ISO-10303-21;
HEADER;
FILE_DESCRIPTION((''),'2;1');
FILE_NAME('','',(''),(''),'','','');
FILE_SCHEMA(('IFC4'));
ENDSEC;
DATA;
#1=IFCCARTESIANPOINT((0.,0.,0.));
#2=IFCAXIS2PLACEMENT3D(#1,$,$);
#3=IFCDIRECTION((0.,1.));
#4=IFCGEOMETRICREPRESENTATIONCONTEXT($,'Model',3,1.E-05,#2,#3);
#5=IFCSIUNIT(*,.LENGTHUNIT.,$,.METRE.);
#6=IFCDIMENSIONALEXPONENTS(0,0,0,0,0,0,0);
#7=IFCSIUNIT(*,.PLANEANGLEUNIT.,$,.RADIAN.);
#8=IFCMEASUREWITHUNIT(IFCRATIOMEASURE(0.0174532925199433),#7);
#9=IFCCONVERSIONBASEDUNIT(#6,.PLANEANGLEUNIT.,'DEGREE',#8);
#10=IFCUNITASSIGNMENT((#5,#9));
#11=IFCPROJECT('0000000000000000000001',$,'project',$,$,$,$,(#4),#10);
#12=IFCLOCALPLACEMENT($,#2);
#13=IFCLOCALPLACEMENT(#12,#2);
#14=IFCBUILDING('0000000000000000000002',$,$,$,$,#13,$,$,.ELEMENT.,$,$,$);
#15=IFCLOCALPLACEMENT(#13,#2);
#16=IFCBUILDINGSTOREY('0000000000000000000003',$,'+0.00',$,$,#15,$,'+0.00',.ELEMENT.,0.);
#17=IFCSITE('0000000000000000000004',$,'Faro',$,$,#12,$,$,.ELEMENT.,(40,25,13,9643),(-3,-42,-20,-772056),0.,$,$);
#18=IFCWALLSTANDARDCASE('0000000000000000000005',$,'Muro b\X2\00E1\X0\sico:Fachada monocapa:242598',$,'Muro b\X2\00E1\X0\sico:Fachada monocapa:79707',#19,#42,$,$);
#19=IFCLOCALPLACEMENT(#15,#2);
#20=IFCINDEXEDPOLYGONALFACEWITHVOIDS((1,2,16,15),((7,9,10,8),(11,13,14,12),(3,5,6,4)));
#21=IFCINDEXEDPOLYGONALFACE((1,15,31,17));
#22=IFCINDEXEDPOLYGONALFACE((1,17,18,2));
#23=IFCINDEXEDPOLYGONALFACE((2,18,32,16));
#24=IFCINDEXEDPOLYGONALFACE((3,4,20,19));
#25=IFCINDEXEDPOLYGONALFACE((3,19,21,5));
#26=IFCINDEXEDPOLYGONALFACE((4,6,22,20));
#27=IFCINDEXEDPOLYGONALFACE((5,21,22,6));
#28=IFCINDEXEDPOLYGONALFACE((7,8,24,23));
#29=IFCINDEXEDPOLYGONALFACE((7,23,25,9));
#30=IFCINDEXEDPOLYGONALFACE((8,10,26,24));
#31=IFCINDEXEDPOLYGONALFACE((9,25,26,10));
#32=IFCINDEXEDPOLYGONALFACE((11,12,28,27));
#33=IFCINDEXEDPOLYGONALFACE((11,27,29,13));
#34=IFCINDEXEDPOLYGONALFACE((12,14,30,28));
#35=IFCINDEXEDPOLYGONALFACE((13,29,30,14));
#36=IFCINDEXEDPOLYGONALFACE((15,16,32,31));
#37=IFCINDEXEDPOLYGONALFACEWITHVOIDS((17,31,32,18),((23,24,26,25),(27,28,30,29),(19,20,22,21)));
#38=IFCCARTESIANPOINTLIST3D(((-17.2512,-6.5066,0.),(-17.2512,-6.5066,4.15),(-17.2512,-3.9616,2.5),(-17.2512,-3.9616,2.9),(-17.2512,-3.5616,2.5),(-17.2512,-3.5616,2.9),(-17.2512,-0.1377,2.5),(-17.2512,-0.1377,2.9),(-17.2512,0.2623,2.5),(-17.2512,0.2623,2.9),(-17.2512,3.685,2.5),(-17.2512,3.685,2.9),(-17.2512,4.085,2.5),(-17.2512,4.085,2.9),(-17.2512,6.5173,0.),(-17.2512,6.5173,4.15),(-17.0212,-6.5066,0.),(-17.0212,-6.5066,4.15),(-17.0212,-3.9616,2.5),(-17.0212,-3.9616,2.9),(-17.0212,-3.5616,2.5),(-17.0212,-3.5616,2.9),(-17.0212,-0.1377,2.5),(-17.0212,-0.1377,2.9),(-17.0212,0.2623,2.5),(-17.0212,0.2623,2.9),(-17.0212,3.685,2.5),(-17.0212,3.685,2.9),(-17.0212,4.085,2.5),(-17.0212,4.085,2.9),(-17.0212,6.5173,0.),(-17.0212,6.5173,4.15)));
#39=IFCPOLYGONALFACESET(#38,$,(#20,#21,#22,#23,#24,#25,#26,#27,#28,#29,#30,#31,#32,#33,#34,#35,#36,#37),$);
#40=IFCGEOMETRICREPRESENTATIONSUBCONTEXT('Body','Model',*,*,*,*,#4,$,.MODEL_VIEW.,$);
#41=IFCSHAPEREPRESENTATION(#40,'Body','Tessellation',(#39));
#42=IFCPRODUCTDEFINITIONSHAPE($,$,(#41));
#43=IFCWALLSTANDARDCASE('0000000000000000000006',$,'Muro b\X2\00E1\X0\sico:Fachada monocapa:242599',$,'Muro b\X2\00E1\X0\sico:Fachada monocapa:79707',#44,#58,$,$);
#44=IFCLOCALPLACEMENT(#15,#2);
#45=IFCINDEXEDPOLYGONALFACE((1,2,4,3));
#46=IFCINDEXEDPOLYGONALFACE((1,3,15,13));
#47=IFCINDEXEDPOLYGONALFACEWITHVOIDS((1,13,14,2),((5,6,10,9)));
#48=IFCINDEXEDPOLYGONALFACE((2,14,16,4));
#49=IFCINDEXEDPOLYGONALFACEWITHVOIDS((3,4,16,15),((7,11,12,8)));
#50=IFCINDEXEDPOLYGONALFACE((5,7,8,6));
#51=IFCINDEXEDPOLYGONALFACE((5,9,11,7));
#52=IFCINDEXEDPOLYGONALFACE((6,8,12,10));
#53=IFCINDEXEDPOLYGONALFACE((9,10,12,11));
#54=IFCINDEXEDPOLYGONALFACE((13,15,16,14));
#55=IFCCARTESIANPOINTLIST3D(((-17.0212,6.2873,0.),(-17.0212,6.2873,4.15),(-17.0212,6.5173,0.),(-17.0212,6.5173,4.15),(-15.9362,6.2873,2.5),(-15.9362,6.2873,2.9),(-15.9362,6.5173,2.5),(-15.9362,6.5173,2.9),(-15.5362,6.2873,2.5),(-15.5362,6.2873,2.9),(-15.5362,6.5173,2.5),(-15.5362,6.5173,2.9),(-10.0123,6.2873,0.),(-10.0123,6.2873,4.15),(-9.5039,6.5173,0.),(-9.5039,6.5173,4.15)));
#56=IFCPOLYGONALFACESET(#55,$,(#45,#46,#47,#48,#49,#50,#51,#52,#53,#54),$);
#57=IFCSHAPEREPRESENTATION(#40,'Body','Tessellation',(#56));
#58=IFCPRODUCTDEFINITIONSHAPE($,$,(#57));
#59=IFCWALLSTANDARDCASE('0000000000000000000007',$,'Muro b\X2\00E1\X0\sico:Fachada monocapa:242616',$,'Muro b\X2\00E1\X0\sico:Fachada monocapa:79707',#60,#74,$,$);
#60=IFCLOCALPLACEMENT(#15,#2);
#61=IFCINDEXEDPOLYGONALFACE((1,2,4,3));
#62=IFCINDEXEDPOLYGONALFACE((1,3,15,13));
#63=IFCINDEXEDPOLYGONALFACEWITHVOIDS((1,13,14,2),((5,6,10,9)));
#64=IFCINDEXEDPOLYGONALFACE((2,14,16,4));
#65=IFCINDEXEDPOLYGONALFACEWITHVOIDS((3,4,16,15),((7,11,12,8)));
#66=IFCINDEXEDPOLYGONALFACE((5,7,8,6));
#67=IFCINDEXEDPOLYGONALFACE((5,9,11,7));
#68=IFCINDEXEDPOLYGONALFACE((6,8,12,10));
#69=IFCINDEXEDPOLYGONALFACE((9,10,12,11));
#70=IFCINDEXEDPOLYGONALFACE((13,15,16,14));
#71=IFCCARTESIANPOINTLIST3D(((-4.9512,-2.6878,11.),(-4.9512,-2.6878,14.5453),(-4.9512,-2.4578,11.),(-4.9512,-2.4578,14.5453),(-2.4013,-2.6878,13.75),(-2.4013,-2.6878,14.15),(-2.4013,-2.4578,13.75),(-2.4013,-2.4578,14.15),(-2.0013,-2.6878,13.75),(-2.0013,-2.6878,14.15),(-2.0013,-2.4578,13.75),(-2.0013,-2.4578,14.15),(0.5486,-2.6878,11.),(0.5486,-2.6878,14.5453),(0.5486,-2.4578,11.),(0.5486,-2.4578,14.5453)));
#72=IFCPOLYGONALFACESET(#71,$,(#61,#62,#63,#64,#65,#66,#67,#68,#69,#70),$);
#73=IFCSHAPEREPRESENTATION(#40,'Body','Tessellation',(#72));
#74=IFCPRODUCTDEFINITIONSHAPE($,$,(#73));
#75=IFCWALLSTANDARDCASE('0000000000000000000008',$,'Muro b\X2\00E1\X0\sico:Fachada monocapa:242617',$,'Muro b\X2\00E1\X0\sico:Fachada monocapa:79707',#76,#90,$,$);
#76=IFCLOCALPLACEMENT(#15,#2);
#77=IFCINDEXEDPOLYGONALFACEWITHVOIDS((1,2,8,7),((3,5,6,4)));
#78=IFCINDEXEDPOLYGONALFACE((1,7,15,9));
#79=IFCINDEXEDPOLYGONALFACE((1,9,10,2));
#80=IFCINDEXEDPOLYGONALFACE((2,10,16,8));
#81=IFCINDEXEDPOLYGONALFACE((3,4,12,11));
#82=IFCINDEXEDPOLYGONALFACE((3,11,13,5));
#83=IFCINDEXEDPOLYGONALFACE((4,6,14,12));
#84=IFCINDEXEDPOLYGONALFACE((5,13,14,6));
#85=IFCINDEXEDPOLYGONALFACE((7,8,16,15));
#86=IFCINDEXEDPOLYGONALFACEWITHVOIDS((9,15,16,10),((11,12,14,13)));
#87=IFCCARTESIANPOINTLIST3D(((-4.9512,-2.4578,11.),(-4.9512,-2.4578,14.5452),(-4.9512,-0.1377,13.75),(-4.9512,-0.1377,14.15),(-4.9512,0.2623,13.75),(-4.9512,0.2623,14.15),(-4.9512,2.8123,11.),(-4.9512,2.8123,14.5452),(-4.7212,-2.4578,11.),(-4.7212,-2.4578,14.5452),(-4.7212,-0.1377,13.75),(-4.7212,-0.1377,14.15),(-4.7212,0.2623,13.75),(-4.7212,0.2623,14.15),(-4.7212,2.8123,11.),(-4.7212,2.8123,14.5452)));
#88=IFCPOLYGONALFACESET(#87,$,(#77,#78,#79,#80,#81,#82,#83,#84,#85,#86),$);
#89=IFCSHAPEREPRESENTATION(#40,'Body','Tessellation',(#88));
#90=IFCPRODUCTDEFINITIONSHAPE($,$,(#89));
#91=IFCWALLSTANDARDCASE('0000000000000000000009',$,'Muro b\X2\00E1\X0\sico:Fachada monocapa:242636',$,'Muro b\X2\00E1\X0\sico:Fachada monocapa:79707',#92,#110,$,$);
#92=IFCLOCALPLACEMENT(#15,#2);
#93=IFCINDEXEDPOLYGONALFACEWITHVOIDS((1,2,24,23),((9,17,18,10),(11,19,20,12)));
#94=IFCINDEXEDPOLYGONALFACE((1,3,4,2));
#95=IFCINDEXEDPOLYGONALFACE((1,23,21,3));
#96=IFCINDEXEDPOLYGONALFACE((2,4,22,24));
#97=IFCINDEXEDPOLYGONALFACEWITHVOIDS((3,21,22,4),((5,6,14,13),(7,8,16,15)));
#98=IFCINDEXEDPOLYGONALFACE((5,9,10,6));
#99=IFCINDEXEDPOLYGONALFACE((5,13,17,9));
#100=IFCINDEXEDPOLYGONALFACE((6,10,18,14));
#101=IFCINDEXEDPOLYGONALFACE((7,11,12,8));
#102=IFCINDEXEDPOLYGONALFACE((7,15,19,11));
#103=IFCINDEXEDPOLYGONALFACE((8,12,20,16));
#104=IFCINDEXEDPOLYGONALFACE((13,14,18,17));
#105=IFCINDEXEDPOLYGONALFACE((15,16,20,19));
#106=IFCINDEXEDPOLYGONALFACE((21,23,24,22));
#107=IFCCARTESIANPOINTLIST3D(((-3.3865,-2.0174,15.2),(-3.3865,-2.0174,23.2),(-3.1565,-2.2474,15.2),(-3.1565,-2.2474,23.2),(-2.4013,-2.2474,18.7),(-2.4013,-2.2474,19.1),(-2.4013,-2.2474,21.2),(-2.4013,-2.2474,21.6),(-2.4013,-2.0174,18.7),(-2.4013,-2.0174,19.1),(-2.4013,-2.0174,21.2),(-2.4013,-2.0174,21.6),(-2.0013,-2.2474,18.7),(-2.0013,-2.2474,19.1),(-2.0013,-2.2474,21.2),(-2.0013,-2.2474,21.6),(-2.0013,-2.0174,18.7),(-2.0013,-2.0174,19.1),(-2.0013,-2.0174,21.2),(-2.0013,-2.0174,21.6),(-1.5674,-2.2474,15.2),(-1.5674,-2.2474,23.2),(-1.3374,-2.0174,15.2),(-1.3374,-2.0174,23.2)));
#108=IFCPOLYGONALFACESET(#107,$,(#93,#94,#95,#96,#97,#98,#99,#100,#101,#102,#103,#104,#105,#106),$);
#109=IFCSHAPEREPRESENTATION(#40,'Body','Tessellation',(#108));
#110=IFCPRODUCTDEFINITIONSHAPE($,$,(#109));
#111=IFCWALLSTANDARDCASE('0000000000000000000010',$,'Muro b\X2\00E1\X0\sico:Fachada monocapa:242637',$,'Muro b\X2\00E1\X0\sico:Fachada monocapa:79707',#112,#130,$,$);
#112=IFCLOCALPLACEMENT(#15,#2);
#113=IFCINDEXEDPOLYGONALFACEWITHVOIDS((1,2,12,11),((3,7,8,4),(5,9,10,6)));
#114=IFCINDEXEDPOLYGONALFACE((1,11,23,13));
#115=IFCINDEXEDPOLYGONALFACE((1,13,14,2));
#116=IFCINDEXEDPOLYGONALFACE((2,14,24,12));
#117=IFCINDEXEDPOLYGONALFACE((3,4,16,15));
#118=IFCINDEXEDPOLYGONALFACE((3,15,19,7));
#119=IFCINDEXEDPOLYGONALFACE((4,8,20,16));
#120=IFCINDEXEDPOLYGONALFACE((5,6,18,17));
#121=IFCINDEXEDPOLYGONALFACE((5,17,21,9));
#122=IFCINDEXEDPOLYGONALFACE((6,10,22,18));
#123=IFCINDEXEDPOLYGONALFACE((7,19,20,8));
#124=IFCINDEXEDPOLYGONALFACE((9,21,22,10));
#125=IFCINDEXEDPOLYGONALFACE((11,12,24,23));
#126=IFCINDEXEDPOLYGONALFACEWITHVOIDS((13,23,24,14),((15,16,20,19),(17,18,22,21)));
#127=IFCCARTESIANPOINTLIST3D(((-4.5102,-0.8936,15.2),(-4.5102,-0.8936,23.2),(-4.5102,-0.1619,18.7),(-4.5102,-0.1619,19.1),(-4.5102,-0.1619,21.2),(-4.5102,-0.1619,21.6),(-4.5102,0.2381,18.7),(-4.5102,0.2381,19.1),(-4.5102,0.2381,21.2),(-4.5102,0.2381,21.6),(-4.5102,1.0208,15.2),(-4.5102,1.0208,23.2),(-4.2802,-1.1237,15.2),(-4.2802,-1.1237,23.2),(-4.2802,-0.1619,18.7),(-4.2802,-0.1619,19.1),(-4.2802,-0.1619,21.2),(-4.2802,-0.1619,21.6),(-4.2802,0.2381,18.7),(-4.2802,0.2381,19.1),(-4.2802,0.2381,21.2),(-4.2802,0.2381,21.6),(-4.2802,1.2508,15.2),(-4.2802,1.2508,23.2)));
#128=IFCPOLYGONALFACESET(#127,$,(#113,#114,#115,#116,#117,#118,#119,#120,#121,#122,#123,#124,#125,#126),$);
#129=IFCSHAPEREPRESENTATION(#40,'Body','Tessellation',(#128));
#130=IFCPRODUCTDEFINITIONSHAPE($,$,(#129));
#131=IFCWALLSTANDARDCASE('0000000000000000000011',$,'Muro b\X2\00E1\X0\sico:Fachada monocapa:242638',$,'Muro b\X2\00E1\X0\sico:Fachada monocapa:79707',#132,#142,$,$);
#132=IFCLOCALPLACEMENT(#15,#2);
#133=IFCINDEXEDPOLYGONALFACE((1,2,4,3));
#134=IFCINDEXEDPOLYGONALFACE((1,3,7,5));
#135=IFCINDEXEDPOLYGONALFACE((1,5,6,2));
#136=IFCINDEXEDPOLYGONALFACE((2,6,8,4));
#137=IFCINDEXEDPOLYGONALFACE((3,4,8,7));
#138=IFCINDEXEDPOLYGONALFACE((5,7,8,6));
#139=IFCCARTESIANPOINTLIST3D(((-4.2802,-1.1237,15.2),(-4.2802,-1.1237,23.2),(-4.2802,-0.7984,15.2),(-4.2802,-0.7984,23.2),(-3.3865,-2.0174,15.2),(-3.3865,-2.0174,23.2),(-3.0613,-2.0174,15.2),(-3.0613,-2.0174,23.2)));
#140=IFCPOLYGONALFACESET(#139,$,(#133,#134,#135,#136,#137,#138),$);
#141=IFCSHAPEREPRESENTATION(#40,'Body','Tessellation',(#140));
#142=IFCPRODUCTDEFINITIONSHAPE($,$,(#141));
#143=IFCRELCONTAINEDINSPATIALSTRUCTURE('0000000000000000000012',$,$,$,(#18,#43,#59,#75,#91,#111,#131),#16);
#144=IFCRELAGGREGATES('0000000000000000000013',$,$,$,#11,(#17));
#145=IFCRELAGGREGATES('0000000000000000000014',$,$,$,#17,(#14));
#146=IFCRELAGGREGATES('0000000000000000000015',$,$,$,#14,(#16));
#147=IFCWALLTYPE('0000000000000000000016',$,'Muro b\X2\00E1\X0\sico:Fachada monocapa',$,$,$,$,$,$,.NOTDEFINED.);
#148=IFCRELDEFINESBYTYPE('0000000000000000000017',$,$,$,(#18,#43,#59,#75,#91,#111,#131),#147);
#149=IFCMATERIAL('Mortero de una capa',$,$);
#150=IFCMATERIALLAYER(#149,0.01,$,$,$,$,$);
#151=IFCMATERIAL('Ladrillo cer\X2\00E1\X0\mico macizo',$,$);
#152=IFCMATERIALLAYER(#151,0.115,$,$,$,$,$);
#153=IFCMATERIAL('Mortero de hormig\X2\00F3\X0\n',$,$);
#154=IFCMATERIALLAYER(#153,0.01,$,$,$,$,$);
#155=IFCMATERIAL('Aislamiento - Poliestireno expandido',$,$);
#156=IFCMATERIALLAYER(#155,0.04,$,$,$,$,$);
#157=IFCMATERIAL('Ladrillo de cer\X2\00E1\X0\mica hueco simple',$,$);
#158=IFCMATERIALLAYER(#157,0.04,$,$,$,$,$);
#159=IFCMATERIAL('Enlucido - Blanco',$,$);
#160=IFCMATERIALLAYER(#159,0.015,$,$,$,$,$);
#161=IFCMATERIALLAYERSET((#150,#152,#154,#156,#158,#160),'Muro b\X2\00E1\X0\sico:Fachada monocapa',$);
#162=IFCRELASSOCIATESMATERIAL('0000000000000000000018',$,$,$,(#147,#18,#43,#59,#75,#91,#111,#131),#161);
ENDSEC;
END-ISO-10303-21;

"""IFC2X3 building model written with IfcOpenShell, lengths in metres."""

from ifc_helpers import new_model, entity, si_unit, converted_unit, direction, frame, frame_2d, origin, place, context, subcontext, project, spatial, polyline, rectangle, outline, extrude, material, layer, layer_set, layer_usage, type_object, element, save


model = new_model("IFC2X3")

# Units and contexts
model_context = context("Model", 3, precision=1e-05, world=origin(), true_north=direction((0.0, 1.0)))
body_context = subcontext(model_context, "Body", "Model", "MODEL_VIEW")
ifc_project = project(units=[si_unit("LENGTHUNIT", "METRE"), converted_unit("PLANEANGLEUNIT", "DEGREE", entity("IfcRatioMeasure", 0.0174532925199433), si_unit("PLANEANGLEUNIT", "RADIAN"), dimensions=[0, 0, 0, 0, 0, 0, 0])], contexts=[model_context])

# Site, building, storey
site_placement = place(None, origin())
site = spatial("IfcSite", under=ifc_project, at=site_placement, Name="Faro", CompositionType="ELEMENT", RefLatitude=(40, 25, 13, 9643), RefLongitude=(-3, -42, -20, -772056), RefElevation=0.0)
building_placement = place(site_placement, origin())
building = spatial("IfcBuilding", under=site, at=building_placement, CompositionType="ELEMENT")
storey_placement = place(building_placement, origin())
storey = spatial("IfcBuildingStorey", under=building, at=storey_placement, Name="+0.00", LongName="+0.00", CompositionType="ELEMENT", Elevation=0.0)

# Wall, openings
ifc_material_1 = material(Name="Mortero de una capa")
ifc_layer_1 = layer(ifc_material_1, 0.01)
ifc_material_2 = material(Name="Ladrillo cerámico macizo")
ifc_layer_2 = layer(ifc_material_2, 0.115)
ifc_material_3 = material(Name="Mortero de hormigón")
ifc_layer_3 = layer(ifc_material_3, 0.01)
ifc_material_4 = material(Name="Aislamiento - Poliestireno expandido")
ifc_layer_4 = layer(ifc_material_4, 0.04)
ifc_material_5 = material(Name="Ladrillo de cerámica hueco simple")
ifc_layer_5 = layer(ifc_material_5, 0.04)
ifc_material_6 = material(Name="Enlucido - Blanco")
ifc_layer_6 = layer(ifc_material_6, 0.015)
ifc_layer_set = layer_set([ifc_layer_1, ifc_layer_2, ifc_layer_3, ifc_layer_4, ifc_layer_5, ifc_layer_6], Name="Muro básico:Fachada monocapa")
ifc_layer_usage_1 = layer_usage(ifc_layer_set, "AXIS2", "POSITIVE", -0.115)
wall_type = type_object("IfcWallType", Name="Muro básico:Fachada monocapa", PredefinedType="NOTDEFINED", material=ifc_layer_set)
wall_1_placement = place(storey_placement, frame((-17.1362, 6.5173, 0.0), z_axis=(0.0, 0.0, 1.0), x_axis=(0.0, -1.0, 0.0)))
wall_1 = element("IfcWallStandardCase", 1, at=wall_1_placement, inside=storey, type_object=wall_type, material=ifc_layer_usage_1, Name="Muro básico:Fachada monocapa:242598", ObjectType="Muro básico:Fachada monocapa:79707", context=body_context, shape_type="SweptSolid", body=[
    extrude(rectangle(XDim=13.0238, YDim=0.23, at=frame_2d((6.5119, 0.0), x_axis=(-1.0, 0.0))), origin(), (0.0, 0.0, 1.0), 4.15),
])
opening_1_placement = place(wall_1_placement, frame((6.655, 0.115, 2.5)))
element("IfcOpeningElement", 2, at=opening_1_placement, cuts=wall_1, ObjectType="Opening", context=body_context, shape_type="SweptSolid", body=[
    extrude(rectangle(XDim=0.4, YDim=0.4, at=frame_2d((0.2, 0.2), x_axis=(1.0, 0.0))), frame((0.0, 0.0, 0.0), z_axis=(0.0, -1.0, 0.0), x_axis=(0.0, 0.0, 1.0)), (0.0, 0.0, 1.0), 0.23),
])
opening_2_placement = place(wall_1_placement, frame((10.4788, 0.115, 2.5)))
element("IfcOpeningElement", 3, at=opening_2_placement, cuts=wall_1, ObjectType="Opening", context=body_context, shape_type="SweptSolid", body=[
    extrude(rectangle(XDim=0.4, YDim=0.4, at=frame_2d((0.2, 0.2), x_axis=(1.0, 0.0))), frame((0.0, 0.0, 0.0), z_axis=(0.0, -1.0, 0.0), x_axis=(0.0, 0.0, 1.0)), (0.0, 0.0, 1.0), 0.23),
])
opening_3_placement = place(wall_1_placement, frame((2.8323, 0.115, 2.5)))
element("IfcOpeningElement", 4, at=opening_3_placement, cuts=wall_1, ObjectType="Opening", context=body_context, shape_type="SweptSolid", body=[
    extrude(rectangle(XDim=0.4, YDim=0.4, at=frame_2d((0.2, 0.2), x_axis=(1.0, 0.0))), frame((0.0, 0.0, 0.0), z_axis=(0.0, -1.0, 0.0), x_axis=(0.0, 0.0, 1.0)), (0.0, 0.0, 1.0), 0.23),
])

# Walls, openings
ifc_layer_usage_2 = layer_usage(ifc_layer_set, "AXIS2", "POSITIVE", -0.115)
wall_2_placement = place(storey_placement, frame((-9.5039, 6.4023, 0.0), z_axis=(0.0, 0.0, 1.0), x_axis=(-1.0, 0.0, 0.0)))
wall_2 = element("IfcWallStandardCase", 5, at=wall_2_placement, inside=storey, type_object=wall_type, material=ifc_layer_usage_2, Name="Muro básico:Fachada monocapa:242599", ObjectType="Muro básico:Fachada monocapa:79707", context=body_context, shape_type="SweptSolid", body=[
    extrude(outline(polyline([(7.5173, -0.115), (7.5173, 0.115), (0.5084, 0.115), (0.0, -0.115), (0.558, -0.115), (7.5173, -0.115)])), origin(), (0.0, 0.0, 1.0), 4.15),
])
opening_4_placement = place(wall_2_placement, frame((6.4323, 0.115, 2.5)))
element("IfcOpeningElement", 6, at=opening_4_placement, cuts=wall_2, ObjectType="Opening", context=body_context, shape_type="SweptSolid", body=[
    extrude(rectangle(XDim=0.4, YDim=0.4, at=frame_2d((0.2, 0.2), x_axis=(1.0, 0.0))), frame((0.0, 0.0, 0.0), z_axis=(0.0, -1.0, 0.0), x_axis=(0.0, 0.0, 1.0)), (0.0, 0.0, 1.0), 0.23),
])
ifc_layer_usage_3 = layer_usage(ifc_layer_set, "AXIS2", "POSITIVE", -0.115)
wall_3_placement = place(storey_placement, frame((-4.9512, -2.5728, 11.0)))
wall_3 = element("IfcWallStandardCase", 7, at=wall_3_placement, inside=storey, type_object=wall_type, material=ifc_layer_usage_3, Name="Muro básico:Fachada monocapa:242616", ObjectType="Muro básico:Fachada monocapa:79707", context=body_context, shape_type="SweptSolid", body=[
    extrude(rectangle(XDim=5.4998, YDim=0.23, at=frame_2d((2.7499, 0.0), x_axis=(-1.0, 0.0))), origin(), (0.0, 0.0, 1.0), 3.5453),
])
opening_5_placement = place(wall_3_placement, frame((2.9499, 0.115, 2.75)))
element("IfcOpeningElement", 8, at=opening_5_placement, cuts=wall_3, ObjectType="Opening", context=body_context, shape_type="SweptSolid", body=[
    extrude(rectangle(XDim=0.4, YDim=0.4, at=frame_2d((0.2, 0.2), x_axis=(1.0, 0.0))), frame((0.0, 0.0, 0.0), z_axis=(0.0, -1.0, 0.0), x_axis=(0.0, 0.0, 1.0)), (0.0, 0.0, 1.0), 0.23),
])
ifc_layer_usage_4 = layer_usage(ifc_layer_set, "AXIS2", "POSITIVE", -0.115)
wall_4_placement = place(storey_placement, frame((-4.8362, 2.8123, 11.0), z_axis=(0.0, 0.0, 1.0), x_axis=(0.0, -1.0, 0.0)))
wall_4 = element("IfcWallStandardCase", 9, at=wall_4_placement, inside=storey, type_object=wall_type, material=ifc_layer_usage_4, Name="Muro básico:Fachada monocapa:242617", ObjectType="Muro básico:Fachada monocapa:79707", context=body_context, shape_type="SweptSolid", body=[
    extrude(rectangle(XDim=5.2701, YDim=0.23, at=frame_2d((2.6351, 0.0), x_axis=(-1.0, 0.0))), origin(), (0.0, 0.0, 1.0), 3.5452),
])
opening_6_placement = place(wall_4_placement, frame((2.9501, 0.115, 2.75)))
element("IfcOpeningElement", 10, at=opening_6_placement, cuts=wall_4, ObjectType="Opening", context=body_context, shape_type="SweptSolid", body=[
    extrude(rectangle(XDim=0.4, YDim=0.4, at=frame_2d((0.2, 0.2), x_axis=(1.0, 0.0))), frame((0.0, 0.0, 0.0), z_axis=(0.0, -1.0, 0.0), x_axis=(0.0, 0.0, 1.0)), (0.0, 0.0, 1.0), 0.23),
])

# Walls, openings
ifc_layer_usage_5 = layer_usage(ifc_layer_set, "AXIS2", "POSITIVE", -0.115)
wall_5_placement = place(storey_placement, frame((-3.3865, -2.1324, 15.2)))
wall_5 = element("IfcWallStandardCase", 11, at=wall_5_placement, inside=storey, type_object=wall_type, material=ifc_layer_usage_5, Name="Muro básico:Fachada monocapa:242636", ObjectType="Muro básico:Fachada monocapa:79707", context=body_context, shape_type="SweptSolid", body=[
    extrude(outline(polyline([(1.8192, -0.115), (2.0492, 0.115), (0.3253, 0.115), (0.0, 0.115), (0.23, -0.115), (1.8192, -0.115)])), origin(), (0.0, 0.0, 1.0), 8.0),
])
opening_7_placement = place(wall_5_placement, frame((1.3852, 0.115, 3.5)))
element("IfcOpeningElement", 12, at=opening_7_placement, cuts=wall_5, ObjectType="Opening", context=body_context, shape_type="SweptSolid", body=[
    extrude(rectangle(XDim=0.4, YDim=0.4, at=frame_2d((0.2, 0.2), x_axis=(1.0, 0.0))), frame((0.0, 0.0, 0.0), z_axis=(0.0, -1.0, 0.0), x_axis=(0.0, 0.0, 1.0)), (0.0, 0.0, 1.0), 0.23),
])
opening_8_placement = place(wall_5_placement, frame((1.3852, 0.115, 6.0)))
element("IfcOpeningElement", 13, at=opening_8_placement, cuts=wall_5, ObjectType="Opening", context=body_context, shape_type="SweptSolid", body=[
    extrude(rectangle(XDim=0.4, YDim=0.4, at=frame_2d((0.2, 0.2), x_axis=(1.0, 0.0))), frame((0.0, 0.0, 0.0), z_axis=(0.0, -1.0, 0.0), x_axis=(0.0, 0.0, 1.0)), (0.0, 0.0, 1.0), 0.23),
])
ifc_layer_usage_6 = layer_usage(ifc_layer_set, "AXIS2", "POSITIVE", -0.115)
wall_6_placement = place(storey_placement, frame((-4.3952, 1.2508, 15.2), z_axis=(0.0, 0.0, 1.0), x_axis=(0.0, -1.0, 0.0)))
wall_6 = element("IfcWallStandardCase", 14, at=wall_6_placement, inside=storey, type_object=wall_type, material=ifc_layer_usage_6, Name="Muro básico:Fachada monocapa:242637", ObjectType="Muro básico:Fachada monocapa:79707", context=body_context, shape_type="SweptSolid", body=[
    extrude(outline(polyline([(2.1444, -0.115), (2.3744, 0.115), (2.0492, 0.115), (0.3253, 0.115), (0.0, 0.115), (0.23, -0.115), (2.1444, -0.115)])), origin(), (0.0, 0.0, 1.0), 8.0),
])
opening_9_placement = place(wall_6_placement, frame((1.4126, 0.115, 3.5)))
element("IfcOpeningElement", 15, at=opening_9_placement, cuts=wall_6, ObjectType="Opening", context=body_context, shape_type="SweptSolid", body=[
    extrude(rectangle(XDim=0.4, YDim=0.4, at=frame_2d((0.2, 0.2), x_axis=(1.0, 0.0))), frame((0.0, 0.0, 0.0), z_axis=(0.0, -1.0, 0.0), x_axis=(0.0, 0.0, 1.0)), (0.0, 0.0, 1.0), 0.23),
])
opening_10_placement = place(wall_6_placement, frame((1.4126, 0.115, 6.0)))
element("IfcOpeningElement", 16, at=opening_10_placement, cuts=wall_6, ObjectType="Opening", context=body_context, shape_type="SweptSolid", body=[
    extrude(rectangle(XDim=0.4, YDim=0.4, at=frame_2d((0.2, 0.2), x_axis=(1.0, 0.0))), frame((0.0, 0.0, 0.0), z_axis=(0.0, -1.0, 0.0), x_axis=(0.0, 0.0, 1.0)), (0.0, 0.0, 1.0), 0.23),
])

# Wall
ifc_layer_usage_7 = layer_usage(ifc_layer_set, "AXIS2", "POSITIVE", -0.115)
wall_7_placement = place(storey_placement, frame((-4.3616, -0.8797, 15.2), z_axis=(0.0, 0.0, 1.0), x_axis=(0.707093, -0.707121, 0.0)))
element("IfcWallStandardCase", 17, at=wall_7_placement, inside=storey, type_object=wall_type, material=ifc_layer_usage_7, Name="Muro básico:Fachada monocapa:242638", ObjectType="Muro básico:Fachada monocapa:79707", context=body_context, shape_type="SweptSolid", body=[
    extrude(outline(polyline([(1.4939, -0.115), (1.7239, 0.115), (0.0, 0.115), (0.23, -0.115), (1.4939, -0.115)])), origin(), (0.0, 0.0, 1.0), 8.0),
])

save(model, "model.ifc")
